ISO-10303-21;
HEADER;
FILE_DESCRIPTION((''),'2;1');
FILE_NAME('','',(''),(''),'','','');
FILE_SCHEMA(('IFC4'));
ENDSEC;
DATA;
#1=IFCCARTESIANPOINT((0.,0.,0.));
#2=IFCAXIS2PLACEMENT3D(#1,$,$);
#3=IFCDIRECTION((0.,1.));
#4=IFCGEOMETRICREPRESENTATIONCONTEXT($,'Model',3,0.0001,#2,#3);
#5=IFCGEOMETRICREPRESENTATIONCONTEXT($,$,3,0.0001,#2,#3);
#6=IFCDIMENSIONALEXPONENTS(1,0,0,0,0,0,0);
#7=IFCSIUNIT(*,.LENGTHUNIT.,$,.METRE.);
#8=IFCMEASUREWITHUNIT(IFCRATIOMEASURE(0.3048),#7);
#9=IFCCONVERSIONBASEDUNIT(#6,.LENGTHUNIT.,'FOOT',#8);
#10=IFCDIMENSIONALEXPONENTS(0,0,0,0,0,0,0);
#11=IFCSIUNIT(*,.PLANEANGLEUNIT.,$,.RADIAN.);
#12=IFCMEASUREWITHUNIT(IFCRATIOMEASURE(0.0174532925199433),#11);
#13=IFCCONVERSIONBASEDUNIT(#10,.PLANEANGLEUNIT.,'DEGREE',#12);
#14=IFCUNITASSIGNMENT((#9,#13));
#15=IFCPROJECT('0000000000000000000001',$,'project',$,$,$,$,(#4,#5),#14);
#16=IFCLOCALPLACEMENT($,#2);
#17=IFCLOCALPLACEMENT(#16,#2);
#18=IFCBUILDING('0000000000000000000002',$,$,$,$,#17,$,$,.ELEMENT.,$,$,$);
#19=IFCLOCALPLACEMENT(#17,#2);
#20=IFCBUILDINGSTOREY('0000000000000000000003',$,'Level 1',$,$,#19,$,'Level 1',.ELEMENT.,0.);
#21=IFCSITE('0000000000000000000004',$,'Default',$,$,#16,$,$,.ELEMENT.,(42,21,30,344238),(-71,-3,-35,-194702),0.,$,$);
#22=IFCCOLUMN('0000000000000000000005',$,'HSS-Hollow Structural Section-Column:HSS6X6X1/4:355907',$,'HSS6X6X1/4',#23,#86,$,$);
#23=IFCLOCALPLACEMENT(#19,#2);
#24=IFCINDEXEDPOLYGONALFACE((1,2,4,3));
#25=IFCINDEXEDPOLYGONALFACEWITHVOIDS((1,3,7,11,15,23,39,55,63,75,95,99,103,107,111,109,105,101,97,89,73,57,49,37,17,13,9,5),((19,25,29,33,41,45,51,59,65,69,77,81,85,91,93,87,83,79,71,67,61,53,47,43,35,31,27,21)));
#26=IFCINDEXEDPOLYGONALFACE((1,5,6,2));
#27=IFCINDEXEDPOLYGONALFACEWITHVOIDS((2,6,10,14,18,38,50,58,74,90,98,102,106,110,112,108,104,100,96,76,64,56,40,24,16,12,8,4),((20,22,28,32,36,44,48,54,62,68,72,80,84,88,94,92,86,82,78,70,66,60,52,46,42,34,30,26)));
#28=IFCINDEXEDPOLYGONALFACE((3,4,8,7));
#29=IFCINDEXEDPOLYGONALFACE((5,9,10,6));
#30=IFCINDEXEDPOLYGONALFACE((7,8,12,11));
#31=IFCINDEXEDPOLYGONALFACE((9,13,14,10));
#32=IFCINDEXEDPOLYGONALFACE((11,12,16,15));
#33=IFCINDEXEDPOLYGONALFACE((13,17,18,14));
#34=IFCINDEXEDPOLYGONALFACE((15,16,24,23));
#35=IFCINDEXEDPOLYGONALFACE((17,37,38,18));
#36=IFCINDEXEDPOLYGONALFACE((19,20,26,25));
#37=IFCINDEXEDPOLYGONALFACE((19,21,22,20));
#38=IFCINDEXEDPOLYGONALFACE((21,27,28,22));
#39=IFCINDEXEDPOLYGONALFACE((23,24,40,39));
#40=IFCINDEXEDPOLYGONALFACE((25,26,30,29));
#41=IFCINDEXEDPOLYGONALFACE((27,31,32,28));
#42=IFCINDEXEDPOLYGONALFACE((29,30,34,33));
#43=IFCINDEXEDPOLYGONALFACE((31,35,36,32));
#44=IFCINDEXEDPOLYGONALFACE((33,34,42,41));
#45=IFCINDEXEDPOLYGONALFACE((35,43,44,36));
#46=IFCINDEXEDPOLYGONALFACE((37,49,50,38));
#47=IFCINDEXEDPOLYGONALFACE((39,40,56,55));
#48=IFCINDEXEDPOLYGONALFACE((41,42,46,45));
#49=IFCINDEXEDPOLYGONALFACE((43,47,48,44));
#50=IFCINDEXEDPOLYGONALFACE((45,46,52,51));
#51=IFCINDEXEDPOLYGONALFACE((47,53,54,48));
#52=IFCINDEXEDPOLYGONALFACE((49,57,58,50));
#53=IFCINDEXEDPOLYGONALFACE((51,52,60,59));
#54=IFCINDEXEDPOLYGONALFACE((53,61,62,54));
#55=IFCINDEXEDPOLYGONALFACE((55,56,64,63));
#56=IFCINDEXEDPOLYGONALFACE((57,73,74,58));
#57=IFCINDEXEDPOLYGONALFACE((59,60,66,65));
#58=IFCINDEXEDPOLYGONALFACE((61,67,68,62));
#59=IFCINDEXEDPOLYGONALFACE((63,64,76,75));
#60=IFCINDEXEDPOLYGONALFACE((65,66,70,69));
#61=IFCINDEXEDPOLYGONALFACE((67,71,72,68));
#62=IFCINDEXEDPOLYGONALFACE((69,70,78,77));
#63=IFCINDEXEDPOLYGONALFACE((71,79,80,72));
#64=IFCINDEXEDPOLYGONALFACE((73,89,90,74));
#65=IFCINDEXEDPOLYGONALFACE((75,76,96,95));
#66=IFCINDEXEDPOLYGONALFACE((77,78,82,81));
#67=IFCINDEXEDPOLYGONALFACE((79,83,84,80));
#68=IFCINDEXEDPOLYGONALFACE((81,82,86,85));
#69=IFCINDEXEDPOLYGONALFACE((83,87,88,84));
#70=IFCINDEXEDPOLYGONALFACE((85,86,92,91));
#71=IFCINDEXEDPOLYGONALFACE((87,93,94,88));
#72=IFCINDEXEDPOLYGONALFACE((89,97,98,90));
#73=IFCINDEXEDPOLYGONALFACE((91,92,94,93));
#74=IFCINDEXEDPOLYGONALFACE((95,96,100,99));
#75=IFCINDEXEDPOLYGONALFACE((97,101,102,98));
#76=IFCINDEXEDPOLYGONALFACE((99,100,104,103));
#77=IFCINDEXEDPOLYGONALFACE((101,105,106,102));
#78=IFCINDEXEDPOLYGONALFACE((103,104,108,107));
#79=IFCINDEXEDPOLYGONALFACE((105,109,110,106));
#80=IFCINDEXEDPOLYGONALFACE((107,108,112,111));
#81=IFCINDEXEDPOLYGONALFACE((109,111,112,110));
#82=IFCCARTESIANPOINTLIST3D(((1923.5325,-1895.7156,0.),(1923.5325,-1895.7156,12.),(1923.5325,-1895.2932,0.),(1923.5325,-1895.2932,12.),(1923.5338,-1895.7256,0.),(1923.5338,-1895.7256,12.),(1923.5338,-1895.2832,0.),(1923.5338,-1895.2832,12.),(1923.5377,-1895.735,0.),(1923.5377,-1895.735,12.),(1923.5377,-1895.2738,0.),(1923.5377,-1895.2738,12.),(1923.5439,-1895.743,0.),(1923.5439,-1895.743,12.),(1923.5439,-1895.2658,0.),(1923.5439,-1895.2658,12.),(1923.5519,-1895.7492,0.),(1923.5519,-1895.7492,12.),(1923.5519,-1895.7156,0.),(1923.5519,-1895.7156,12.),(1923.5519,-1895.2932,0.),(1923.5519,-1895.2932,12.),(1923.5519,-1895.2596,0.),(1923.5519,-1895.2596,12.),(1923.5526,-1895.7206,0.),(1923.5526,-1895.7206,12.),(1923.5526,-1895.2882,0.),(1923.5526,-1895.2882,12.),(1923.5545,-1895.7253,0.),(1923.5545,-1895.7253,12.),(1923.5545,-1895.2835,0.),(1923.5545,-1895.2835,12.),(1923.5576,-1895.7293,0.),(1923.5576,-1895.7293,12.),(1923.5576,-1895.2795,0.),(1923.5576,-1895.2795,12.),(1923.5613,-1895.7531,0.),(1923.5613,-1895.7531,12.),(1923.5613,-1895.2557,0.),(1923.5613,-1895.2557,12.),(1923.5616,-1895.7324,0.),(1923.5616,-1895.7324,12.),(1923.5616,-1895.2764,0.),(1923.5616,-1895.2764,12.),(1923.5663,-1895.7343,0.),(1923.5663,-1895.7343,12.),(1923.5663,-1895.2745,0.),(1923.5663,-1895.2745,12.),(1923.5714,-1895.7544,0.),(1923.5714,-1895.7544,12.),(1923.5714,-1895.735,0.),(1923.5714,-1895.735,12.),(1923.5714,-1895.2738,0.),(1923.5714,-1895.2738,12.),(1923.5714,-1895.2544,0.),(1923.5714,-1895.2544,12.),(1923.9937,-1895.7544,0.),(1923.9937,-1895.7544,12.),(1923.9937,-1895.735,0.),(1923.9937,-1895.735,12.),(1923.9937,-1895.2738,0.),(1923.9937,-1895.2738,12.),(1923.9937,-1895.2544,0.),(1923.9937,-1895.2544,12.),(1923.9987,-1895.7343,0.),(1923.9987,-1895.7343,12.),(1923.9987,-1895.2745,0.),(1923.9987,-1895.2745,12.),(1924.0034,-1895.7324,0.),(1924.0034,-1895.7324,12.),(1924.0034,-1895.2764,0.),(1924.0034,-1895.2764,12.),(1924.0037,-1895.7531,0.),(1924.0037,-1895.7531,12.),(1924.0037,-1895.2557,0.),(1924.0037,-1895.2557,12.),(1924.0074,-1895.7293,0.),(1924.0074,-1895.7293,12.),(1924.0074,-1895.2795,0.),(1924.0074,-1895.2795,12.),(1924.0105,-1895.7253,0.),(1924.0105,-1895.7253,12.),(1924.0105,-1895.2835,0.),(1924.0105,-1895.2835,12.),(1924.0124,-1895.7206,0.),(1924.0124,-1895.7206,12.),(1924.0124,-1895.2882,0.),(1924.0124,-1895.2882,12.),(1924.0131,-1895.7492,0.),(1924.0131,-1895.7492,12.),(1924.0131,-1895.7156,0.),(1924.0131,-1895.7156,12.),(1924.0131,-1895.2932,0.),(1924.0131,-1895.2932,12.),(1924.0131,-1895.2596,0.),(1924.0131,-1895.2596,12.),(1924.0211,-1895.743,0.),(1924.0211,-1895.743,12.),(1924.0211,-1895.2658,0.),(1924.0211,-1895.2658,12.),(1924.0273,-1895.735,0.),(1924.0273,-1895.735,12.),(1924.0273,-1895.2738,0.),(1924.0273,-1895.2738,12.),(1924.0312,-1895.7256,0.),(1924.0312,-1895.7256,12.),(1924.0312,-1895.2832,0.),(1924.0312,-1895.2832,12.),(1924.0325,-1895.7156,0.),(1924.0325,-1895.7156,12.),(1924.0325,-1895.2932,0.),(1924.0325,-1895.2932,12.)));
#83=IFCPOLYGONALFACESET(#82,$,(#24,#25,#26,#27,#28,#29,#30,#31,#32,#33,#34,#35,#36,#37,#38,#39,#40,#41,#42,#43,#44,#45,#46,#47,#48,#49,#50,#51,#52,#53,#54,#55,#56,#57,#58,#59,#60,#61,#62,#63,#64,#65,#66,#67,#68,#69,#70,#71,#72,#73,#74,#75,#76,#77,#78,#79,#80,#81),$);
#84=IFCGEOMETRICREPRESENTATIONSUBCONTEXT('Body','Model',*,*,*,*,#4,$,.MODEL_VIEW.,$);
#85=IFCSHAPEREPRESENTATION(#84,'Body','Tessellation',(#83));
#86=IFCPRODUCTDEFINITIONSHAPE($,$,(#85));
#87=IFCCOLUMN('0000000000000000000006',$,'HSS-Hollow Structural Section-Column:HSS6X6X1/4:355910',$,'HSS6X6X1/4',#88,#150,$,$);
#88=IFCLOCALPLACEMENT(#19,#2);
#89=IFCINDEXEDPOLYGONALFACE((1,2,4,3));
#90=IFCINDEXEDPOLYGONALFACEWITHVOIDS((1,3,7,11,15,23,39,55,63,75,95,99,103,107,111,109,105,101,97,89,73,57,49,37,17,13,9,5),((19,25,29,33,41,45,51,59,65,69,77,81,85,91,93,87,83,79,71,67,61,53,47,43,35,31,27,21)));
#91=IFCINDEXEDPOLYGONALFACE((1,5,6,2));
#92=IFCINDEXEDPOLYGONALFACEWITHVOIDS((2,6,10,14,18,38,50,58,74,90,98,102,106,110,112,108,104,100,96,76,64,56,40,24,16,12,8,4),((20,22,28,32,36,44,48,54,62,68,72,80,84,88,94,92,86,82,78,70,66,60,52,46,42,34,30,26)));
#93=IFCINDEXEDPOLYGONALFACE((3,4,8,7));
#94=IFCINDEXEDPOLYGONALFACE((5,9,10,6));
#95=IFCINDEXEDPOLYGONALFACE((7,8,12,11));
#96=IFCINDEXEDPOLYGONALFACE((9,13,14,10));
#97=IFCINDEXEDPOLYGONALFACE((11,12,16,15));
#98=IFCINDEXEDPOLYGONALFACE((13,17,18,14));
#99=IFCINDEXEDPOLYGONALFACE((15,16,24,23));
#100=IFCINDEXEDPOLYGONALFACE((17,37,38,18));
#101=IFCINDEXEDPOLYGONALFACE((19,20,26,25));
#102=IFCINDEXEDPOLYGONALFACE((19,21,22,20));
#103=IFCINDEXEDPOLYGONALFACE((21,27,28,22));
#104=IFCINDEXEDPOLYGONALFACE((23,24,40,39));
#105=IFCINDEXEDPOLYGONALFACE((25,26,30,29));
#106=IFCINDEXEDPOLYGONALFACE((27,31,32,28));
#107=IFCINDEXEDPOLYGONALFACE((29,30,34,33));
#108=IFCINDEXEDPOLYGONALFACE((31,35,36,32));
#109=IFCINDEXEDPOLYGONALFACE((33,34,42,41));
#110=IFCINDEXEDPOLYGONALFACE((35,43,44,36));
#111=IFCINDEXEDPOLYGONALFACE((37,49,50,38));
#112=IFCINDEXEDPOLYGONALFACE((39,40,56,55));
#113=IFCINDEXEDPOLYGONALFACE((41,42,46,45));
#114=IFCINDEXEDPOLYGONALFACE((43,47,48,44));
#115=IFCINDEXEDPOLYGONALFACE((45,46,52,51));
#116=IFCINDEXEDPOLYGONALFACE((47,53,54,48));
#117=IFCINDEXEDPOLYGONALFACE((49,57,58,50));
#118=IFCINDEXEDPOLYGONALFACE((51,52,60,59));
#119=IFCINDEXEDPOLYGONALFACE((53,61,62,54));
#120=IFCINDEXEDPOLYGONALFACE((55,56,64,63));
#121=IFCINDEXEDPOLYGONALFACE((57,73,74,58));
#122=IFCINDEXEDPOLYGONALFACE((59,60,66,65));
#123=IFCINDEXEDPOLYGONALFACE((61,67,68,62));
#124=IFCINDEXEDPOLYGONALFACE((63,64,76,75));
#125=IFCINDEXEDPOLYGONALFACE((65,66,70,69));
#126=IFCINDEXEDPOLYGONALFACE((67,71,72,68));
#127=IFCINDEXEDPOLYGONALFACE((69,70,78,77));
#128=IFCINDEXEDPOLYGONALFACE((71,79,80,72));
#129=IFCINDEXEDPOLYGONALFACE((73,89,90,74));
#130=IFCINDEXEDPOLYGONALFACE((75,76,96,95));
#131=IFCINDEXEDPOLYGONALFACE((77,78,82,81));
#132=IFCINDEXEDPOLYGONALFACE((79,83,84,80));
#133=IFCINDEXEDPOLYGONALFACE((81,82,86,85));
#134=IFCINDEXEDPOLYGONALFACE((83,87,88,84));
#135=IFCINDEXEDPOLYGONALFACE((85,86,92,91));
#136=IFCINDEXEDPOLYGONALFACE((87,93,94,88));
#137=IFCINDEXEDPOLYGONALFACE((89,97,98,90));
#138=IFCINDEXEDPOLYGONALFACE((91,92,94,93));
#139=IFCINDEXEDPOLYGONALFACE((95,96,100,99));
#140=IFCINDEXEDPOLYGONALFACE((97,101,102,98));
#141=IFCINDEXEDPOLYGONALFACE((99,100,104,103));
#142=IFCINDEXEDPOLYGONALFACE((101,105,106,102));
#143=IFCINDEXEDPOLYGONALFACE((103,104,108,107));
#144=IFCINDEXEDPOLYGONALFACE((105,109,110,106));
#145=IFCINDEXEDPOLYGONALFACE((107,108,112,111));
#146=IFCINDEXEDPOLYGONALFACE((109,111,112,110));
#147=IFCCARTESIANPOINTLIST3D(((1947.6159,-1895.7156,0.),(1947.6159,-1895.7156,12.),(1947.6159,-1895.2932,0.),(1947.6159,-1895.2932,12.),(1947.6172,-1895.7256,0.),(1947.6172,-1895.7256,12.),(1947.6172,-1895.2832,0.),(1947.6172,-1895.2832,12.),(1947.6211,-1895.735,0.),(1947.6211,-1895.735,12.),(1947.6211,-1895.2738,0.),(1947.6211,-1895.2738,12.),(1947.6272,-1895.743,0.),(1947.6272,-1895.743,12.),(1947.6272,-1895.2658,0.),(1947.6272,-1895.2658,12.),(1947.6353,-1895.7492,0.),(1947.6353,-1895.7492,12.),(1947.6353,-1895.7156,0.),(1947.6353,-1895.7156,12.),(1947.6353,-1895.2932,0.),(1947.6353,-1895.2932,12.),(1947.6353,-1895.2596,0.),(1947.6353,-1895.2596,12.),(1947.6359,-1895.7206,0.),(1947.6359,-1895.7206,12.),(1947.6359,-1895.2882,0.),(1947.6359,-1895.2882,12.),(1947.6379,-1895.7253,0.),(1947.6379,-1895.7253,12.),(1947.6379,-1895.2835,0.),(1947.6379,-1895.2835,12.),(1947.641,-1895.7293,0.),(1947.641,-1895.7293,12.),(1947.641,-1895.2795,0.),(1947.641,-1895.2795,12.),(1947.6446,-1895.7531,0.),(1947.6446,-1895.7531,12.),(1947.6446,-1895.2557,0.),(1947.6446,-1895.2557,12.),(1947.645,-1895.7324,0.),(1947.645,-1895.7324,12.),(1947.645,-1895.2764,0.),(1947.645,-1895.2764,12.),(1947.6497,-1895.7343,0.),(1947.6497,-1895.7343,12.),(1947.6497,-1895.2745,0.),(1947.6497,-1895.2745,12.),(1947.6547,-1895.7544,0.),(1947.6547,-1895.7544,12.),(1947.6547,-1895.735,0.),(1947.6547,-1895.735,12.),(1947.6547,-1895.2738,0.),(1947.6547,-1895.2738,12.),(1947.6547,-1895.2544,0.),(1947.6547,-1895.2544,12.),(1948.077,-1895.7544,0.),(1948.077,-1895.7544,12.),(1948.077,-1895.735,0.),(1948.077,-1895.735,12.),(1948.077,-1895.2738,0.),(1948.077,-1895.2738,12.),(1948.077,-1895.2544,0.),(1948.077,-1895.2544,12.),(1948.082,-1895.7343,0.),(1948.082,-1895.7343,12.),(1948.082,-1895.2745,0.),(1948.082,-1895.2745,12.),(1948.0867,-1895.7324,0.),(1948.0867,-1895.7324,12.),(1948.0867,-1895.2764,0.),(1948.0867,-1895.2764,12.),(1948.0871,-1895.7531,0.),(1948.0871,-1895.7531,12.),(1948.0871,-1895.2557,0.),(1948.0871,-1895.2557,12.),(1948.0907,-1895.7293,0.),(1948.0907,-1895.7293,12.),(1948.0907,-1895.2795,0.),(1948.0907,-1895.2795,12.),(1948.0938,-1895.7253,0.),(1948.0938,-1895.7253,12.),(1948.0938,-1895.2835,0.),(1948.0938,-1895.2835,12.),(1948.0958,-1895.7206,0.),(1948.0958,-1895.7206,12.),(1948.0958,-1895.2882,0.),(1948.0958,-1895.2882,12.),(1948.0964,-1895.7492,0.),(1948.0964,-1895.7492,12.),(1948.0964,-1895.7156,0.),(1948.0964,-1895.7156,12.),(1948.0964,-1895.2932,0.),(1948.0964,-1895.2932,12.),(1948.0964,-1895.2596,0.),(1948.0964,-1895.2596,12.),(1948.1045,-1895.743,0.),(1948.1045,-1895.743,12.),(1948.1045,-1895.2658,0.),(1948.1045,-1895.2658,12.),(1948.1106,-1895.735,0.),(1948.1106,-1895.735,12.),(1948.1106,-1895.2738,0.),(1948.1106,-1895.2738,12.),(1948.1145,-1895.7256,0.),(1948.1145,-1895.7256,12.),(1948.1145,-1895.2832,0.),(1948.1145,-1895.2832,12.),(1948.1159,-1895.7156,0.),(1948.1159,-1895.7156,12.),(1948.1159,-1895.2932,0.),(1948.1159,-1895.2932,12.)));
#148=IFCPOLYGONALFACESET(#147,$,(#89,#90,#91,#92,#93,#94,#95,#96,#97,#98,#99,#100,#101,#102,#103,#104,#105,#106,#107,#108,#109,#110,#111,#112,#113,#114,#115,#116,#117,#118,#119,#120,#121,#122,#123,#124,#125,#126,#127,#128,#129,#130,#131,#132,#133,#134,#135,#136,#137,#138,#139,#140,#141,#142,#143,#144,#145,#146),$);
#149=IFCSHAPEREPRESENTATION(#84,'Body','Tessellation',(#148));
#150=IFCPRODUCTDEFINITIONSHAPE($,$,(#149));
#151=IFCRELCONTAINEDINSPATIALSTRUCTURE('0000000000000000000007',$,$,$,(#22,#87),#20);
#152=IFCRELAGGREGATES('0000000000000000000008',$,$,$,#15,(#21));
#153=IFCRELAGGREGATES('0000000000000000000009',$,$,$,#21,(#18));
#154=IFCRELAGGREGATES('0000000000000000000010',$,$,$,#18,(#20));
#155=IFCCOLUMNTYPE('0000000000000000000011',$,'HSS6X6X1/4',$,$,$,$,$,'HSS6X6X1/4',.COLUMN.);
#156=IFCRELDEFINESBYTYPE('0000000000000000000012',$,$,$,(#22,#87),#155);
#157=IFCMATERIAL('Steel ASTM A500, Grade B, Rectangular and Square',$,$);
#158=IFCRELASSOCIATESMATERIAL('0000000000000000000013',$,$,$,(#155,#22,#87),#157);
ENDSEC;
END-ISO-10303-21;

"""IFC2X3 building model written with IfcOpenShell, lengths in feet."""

from ifc_helpers import new_model, entity, si_unit, converted_unit, direction, frame, frame_2d, origin, place, context, subcontext, project, spatial, polyline, circle_curve, parameter, trimmed, segment, composite_curve, outline, extrude, source, transform, mapped, material, type_object, type_shapes, element, save


model = new_model("IFC2X3")

# Units and contexts
model_context = context("Model", 3, precision=0.0001, world=origin(), true_north=direction((0.0, 1.0)))
context_of_model = context(None, 3, precision=0.0001, world=origin(), true_north=direction((0.0, 1.0)))
body_context = subcontext(model_context, "Body", "Model", "MODEL_VIEW")
ifc_project = project(units=[converted_unit("LENGTHUNIT", "FOOT", entity("IfcRatioMeasure", 0.3048), si_unit("LENGTHUNIT", "METRE"), dimensions=[1, 0, 0, 0, 0, 0, 0]), converted_unit("PLANEANGLEUNIT", "DEGREE", entity("IfcRatioMeasure", 0.0174532925199433), si_unit("PLANEANGLEUNIT", "RADIAN"), dimensions=[0, 0, 0, 0, 0, 0, 0])], contexts=[model_context, context_of_model])

# Site, building, storey
site_placement = place(None, origin())
site = spatial("IfcSite", under=ifc_project, at=site_placement, Name="Default", CompositionType="ELEMENT", RefLatitude=(42, 21, 30, 344238), RefLongitude=(-71, -3, -35, -194702), RefElevation=0.0)
building_placement = place(site_placement, origin())
building = spatial("IfcBuilding", under=site, at=building_placement, CompositionType="ELEMENT")
storey_placement = place(building_placement, origin())
storey = spatial("IfcBuildingStorey", under=building, at=storey_placement, Name="Level 1", LongName="Level 1", CompositionType="ELEMENT", Elevation=0.0)

# Columns
ifc_material_1 = material(Name="Steel ASTM A500, Grade B, Rectangular and Square")
column_type = type_object("IfcColumnType", Name="HSS6X6X1/4", ElementType="HSS6X6X1/4", PredefinedType="COLUMN", material=ifc_material_1)
shared_shape = source(origin(), body_context, "Body", "SweptSolid", [
    extrude(outline(composite_curve([segment(polyline([(-0.2112, -0.25), (0.2112, -0.25)]), True, "CONTINUOUS"), segment(trimmed(circle_curve(frame_2d((0.2112, -0.2112), x_axis=(-1.0, 0.0)), 0.0388), [parameter(90.0)], [parameter(180.0)], True, "PARAMETER"), True, "CONTINUOUS"), segment(polyline([(0.25, -0.2112), (0.25, 0.2112)]), True, "CONTINUOUS"), segment(trimmed(circle_curve(frame_2d((0.2112, 0.2112), x_axis=(-1.0, 0.0)), 0.0388), [parameter(180.0)], [parameter(270.0)], True, "PARAMETER"), True, "CONTINUOUS"), segment(polyline([(0.2112, 0.25), (-0.2112, 0.25)]), True, "CONTINUOUS"), segment(trimmed(circle_curve(frame_2d((-0.2112, 0.2112), x_axis=(-1.0, 0.0)), 0.0388), [parameter(270.0)], [parameter(360.0)], True, "PARAMETER"), True, "CONTINUOUS"), segment(polyline([(-0.25, 0.2112), (-0.25, -0.2112)]), True, "CONTINUOUS"), segment(trimmed(circle_curve(frame_2d((-0.2112, -0.2112), x_axis=(-1.0, 0.0)), 0.0388), [parameter(360.0)], [parameter(90.0)], True, "PARAMETER"), True, "CONTINUOUS")], self_intersect=False), holes=[composite_curve([segment(trimmed(circle_curve(frame_2d((-0.2112, -0.2112), x_axis=(-1.0, 0.0)), 0.0194), [parameter(0.0)], [parameter(90.0)], True, "PARAMETER"), False, "CONTINUOUS"), segment(polyline([(-0.2306, -0.2112), (-0.2306, 0.2112)]), True, "CONTINUOUS"), segment(trimmed(circle_curve(frame_2d((-0.2112, 0.2112), x_axis=(-1.0, 0.0)), 0.0194), [parameter(270.0)], [parameter(360.0)], True, "PARAMETER"), False, "CONTINUOUS"), segment(polyline([(-0.2112, 0.2306), (0.2112, 0.2306)]), True, "CONTINUOUS"), segment(trimmed(circle_curve(frame_2d((0.2112, 0.2112), x_axis=(-1.0, 0.0)), 0.0194), [parameter(180.0)], [parameter(270.0)], True, "PARAMETER"), False, "CONTINUOUS"), segment(polyline([(0.2306, 0.2112), (0.2306, -0.2112)]), True, "CONTINUOUS"), segment(trimmed(circle_curve(frame_2d((0.2112, -0.2112), x_axis=(-1.0, 0.0)), 0.0194), [parameter(90.0)], [parameter(180.0)], True, "PARAMETER"), False, "CONTINUOUS"), segment(polyline([(0.2112, -0.2306), (-0.2112, -0.2306)]), True, "CONTINUOUS")], self_intersect=False)]), frame((0.0, 0.0, 0.0), z_axis=(0.0, 0.0, 1.0), x_axis=(-1.0, 0.0, 0.0)), (0.0, 0.0, 1.0), 12.0),
])
type_shapes(column_type, [shared_shape])
for number, where, z_axis, x_axis, name in (
    (1, (1923.7825, -1895.5044, 0.0), (0.0, 0.0, 1.0), (-1.0, 0.0, 0.0), "HSS-Hollow Structural Section-Column:HSS6X6X1/4:355907"),
    (2, (1947.8659, -1895.5044, 0.0), (0.0, 0.0, 1.0), (-1.0, 0.0, 0.0), "HSS-Hollow Structural Section-Column:HSS6X6X1/4:355910"),
):
    element("IfcColumn", number, at=place(storey_placement, frame(where, z_axis=z_axis, x_axis=x_axis)), inside=storey, type_object=column_type, material=ifc_material_1, Name=name, ObjectType="HSS6X6X1/4", context=body_context, shape_type="MappedRepresentation", body=[
        mapped(shared_shape, transform((0.0, 0.0, 0.0), scale=1.0)),
    ])

save(model, "model.ifc")
